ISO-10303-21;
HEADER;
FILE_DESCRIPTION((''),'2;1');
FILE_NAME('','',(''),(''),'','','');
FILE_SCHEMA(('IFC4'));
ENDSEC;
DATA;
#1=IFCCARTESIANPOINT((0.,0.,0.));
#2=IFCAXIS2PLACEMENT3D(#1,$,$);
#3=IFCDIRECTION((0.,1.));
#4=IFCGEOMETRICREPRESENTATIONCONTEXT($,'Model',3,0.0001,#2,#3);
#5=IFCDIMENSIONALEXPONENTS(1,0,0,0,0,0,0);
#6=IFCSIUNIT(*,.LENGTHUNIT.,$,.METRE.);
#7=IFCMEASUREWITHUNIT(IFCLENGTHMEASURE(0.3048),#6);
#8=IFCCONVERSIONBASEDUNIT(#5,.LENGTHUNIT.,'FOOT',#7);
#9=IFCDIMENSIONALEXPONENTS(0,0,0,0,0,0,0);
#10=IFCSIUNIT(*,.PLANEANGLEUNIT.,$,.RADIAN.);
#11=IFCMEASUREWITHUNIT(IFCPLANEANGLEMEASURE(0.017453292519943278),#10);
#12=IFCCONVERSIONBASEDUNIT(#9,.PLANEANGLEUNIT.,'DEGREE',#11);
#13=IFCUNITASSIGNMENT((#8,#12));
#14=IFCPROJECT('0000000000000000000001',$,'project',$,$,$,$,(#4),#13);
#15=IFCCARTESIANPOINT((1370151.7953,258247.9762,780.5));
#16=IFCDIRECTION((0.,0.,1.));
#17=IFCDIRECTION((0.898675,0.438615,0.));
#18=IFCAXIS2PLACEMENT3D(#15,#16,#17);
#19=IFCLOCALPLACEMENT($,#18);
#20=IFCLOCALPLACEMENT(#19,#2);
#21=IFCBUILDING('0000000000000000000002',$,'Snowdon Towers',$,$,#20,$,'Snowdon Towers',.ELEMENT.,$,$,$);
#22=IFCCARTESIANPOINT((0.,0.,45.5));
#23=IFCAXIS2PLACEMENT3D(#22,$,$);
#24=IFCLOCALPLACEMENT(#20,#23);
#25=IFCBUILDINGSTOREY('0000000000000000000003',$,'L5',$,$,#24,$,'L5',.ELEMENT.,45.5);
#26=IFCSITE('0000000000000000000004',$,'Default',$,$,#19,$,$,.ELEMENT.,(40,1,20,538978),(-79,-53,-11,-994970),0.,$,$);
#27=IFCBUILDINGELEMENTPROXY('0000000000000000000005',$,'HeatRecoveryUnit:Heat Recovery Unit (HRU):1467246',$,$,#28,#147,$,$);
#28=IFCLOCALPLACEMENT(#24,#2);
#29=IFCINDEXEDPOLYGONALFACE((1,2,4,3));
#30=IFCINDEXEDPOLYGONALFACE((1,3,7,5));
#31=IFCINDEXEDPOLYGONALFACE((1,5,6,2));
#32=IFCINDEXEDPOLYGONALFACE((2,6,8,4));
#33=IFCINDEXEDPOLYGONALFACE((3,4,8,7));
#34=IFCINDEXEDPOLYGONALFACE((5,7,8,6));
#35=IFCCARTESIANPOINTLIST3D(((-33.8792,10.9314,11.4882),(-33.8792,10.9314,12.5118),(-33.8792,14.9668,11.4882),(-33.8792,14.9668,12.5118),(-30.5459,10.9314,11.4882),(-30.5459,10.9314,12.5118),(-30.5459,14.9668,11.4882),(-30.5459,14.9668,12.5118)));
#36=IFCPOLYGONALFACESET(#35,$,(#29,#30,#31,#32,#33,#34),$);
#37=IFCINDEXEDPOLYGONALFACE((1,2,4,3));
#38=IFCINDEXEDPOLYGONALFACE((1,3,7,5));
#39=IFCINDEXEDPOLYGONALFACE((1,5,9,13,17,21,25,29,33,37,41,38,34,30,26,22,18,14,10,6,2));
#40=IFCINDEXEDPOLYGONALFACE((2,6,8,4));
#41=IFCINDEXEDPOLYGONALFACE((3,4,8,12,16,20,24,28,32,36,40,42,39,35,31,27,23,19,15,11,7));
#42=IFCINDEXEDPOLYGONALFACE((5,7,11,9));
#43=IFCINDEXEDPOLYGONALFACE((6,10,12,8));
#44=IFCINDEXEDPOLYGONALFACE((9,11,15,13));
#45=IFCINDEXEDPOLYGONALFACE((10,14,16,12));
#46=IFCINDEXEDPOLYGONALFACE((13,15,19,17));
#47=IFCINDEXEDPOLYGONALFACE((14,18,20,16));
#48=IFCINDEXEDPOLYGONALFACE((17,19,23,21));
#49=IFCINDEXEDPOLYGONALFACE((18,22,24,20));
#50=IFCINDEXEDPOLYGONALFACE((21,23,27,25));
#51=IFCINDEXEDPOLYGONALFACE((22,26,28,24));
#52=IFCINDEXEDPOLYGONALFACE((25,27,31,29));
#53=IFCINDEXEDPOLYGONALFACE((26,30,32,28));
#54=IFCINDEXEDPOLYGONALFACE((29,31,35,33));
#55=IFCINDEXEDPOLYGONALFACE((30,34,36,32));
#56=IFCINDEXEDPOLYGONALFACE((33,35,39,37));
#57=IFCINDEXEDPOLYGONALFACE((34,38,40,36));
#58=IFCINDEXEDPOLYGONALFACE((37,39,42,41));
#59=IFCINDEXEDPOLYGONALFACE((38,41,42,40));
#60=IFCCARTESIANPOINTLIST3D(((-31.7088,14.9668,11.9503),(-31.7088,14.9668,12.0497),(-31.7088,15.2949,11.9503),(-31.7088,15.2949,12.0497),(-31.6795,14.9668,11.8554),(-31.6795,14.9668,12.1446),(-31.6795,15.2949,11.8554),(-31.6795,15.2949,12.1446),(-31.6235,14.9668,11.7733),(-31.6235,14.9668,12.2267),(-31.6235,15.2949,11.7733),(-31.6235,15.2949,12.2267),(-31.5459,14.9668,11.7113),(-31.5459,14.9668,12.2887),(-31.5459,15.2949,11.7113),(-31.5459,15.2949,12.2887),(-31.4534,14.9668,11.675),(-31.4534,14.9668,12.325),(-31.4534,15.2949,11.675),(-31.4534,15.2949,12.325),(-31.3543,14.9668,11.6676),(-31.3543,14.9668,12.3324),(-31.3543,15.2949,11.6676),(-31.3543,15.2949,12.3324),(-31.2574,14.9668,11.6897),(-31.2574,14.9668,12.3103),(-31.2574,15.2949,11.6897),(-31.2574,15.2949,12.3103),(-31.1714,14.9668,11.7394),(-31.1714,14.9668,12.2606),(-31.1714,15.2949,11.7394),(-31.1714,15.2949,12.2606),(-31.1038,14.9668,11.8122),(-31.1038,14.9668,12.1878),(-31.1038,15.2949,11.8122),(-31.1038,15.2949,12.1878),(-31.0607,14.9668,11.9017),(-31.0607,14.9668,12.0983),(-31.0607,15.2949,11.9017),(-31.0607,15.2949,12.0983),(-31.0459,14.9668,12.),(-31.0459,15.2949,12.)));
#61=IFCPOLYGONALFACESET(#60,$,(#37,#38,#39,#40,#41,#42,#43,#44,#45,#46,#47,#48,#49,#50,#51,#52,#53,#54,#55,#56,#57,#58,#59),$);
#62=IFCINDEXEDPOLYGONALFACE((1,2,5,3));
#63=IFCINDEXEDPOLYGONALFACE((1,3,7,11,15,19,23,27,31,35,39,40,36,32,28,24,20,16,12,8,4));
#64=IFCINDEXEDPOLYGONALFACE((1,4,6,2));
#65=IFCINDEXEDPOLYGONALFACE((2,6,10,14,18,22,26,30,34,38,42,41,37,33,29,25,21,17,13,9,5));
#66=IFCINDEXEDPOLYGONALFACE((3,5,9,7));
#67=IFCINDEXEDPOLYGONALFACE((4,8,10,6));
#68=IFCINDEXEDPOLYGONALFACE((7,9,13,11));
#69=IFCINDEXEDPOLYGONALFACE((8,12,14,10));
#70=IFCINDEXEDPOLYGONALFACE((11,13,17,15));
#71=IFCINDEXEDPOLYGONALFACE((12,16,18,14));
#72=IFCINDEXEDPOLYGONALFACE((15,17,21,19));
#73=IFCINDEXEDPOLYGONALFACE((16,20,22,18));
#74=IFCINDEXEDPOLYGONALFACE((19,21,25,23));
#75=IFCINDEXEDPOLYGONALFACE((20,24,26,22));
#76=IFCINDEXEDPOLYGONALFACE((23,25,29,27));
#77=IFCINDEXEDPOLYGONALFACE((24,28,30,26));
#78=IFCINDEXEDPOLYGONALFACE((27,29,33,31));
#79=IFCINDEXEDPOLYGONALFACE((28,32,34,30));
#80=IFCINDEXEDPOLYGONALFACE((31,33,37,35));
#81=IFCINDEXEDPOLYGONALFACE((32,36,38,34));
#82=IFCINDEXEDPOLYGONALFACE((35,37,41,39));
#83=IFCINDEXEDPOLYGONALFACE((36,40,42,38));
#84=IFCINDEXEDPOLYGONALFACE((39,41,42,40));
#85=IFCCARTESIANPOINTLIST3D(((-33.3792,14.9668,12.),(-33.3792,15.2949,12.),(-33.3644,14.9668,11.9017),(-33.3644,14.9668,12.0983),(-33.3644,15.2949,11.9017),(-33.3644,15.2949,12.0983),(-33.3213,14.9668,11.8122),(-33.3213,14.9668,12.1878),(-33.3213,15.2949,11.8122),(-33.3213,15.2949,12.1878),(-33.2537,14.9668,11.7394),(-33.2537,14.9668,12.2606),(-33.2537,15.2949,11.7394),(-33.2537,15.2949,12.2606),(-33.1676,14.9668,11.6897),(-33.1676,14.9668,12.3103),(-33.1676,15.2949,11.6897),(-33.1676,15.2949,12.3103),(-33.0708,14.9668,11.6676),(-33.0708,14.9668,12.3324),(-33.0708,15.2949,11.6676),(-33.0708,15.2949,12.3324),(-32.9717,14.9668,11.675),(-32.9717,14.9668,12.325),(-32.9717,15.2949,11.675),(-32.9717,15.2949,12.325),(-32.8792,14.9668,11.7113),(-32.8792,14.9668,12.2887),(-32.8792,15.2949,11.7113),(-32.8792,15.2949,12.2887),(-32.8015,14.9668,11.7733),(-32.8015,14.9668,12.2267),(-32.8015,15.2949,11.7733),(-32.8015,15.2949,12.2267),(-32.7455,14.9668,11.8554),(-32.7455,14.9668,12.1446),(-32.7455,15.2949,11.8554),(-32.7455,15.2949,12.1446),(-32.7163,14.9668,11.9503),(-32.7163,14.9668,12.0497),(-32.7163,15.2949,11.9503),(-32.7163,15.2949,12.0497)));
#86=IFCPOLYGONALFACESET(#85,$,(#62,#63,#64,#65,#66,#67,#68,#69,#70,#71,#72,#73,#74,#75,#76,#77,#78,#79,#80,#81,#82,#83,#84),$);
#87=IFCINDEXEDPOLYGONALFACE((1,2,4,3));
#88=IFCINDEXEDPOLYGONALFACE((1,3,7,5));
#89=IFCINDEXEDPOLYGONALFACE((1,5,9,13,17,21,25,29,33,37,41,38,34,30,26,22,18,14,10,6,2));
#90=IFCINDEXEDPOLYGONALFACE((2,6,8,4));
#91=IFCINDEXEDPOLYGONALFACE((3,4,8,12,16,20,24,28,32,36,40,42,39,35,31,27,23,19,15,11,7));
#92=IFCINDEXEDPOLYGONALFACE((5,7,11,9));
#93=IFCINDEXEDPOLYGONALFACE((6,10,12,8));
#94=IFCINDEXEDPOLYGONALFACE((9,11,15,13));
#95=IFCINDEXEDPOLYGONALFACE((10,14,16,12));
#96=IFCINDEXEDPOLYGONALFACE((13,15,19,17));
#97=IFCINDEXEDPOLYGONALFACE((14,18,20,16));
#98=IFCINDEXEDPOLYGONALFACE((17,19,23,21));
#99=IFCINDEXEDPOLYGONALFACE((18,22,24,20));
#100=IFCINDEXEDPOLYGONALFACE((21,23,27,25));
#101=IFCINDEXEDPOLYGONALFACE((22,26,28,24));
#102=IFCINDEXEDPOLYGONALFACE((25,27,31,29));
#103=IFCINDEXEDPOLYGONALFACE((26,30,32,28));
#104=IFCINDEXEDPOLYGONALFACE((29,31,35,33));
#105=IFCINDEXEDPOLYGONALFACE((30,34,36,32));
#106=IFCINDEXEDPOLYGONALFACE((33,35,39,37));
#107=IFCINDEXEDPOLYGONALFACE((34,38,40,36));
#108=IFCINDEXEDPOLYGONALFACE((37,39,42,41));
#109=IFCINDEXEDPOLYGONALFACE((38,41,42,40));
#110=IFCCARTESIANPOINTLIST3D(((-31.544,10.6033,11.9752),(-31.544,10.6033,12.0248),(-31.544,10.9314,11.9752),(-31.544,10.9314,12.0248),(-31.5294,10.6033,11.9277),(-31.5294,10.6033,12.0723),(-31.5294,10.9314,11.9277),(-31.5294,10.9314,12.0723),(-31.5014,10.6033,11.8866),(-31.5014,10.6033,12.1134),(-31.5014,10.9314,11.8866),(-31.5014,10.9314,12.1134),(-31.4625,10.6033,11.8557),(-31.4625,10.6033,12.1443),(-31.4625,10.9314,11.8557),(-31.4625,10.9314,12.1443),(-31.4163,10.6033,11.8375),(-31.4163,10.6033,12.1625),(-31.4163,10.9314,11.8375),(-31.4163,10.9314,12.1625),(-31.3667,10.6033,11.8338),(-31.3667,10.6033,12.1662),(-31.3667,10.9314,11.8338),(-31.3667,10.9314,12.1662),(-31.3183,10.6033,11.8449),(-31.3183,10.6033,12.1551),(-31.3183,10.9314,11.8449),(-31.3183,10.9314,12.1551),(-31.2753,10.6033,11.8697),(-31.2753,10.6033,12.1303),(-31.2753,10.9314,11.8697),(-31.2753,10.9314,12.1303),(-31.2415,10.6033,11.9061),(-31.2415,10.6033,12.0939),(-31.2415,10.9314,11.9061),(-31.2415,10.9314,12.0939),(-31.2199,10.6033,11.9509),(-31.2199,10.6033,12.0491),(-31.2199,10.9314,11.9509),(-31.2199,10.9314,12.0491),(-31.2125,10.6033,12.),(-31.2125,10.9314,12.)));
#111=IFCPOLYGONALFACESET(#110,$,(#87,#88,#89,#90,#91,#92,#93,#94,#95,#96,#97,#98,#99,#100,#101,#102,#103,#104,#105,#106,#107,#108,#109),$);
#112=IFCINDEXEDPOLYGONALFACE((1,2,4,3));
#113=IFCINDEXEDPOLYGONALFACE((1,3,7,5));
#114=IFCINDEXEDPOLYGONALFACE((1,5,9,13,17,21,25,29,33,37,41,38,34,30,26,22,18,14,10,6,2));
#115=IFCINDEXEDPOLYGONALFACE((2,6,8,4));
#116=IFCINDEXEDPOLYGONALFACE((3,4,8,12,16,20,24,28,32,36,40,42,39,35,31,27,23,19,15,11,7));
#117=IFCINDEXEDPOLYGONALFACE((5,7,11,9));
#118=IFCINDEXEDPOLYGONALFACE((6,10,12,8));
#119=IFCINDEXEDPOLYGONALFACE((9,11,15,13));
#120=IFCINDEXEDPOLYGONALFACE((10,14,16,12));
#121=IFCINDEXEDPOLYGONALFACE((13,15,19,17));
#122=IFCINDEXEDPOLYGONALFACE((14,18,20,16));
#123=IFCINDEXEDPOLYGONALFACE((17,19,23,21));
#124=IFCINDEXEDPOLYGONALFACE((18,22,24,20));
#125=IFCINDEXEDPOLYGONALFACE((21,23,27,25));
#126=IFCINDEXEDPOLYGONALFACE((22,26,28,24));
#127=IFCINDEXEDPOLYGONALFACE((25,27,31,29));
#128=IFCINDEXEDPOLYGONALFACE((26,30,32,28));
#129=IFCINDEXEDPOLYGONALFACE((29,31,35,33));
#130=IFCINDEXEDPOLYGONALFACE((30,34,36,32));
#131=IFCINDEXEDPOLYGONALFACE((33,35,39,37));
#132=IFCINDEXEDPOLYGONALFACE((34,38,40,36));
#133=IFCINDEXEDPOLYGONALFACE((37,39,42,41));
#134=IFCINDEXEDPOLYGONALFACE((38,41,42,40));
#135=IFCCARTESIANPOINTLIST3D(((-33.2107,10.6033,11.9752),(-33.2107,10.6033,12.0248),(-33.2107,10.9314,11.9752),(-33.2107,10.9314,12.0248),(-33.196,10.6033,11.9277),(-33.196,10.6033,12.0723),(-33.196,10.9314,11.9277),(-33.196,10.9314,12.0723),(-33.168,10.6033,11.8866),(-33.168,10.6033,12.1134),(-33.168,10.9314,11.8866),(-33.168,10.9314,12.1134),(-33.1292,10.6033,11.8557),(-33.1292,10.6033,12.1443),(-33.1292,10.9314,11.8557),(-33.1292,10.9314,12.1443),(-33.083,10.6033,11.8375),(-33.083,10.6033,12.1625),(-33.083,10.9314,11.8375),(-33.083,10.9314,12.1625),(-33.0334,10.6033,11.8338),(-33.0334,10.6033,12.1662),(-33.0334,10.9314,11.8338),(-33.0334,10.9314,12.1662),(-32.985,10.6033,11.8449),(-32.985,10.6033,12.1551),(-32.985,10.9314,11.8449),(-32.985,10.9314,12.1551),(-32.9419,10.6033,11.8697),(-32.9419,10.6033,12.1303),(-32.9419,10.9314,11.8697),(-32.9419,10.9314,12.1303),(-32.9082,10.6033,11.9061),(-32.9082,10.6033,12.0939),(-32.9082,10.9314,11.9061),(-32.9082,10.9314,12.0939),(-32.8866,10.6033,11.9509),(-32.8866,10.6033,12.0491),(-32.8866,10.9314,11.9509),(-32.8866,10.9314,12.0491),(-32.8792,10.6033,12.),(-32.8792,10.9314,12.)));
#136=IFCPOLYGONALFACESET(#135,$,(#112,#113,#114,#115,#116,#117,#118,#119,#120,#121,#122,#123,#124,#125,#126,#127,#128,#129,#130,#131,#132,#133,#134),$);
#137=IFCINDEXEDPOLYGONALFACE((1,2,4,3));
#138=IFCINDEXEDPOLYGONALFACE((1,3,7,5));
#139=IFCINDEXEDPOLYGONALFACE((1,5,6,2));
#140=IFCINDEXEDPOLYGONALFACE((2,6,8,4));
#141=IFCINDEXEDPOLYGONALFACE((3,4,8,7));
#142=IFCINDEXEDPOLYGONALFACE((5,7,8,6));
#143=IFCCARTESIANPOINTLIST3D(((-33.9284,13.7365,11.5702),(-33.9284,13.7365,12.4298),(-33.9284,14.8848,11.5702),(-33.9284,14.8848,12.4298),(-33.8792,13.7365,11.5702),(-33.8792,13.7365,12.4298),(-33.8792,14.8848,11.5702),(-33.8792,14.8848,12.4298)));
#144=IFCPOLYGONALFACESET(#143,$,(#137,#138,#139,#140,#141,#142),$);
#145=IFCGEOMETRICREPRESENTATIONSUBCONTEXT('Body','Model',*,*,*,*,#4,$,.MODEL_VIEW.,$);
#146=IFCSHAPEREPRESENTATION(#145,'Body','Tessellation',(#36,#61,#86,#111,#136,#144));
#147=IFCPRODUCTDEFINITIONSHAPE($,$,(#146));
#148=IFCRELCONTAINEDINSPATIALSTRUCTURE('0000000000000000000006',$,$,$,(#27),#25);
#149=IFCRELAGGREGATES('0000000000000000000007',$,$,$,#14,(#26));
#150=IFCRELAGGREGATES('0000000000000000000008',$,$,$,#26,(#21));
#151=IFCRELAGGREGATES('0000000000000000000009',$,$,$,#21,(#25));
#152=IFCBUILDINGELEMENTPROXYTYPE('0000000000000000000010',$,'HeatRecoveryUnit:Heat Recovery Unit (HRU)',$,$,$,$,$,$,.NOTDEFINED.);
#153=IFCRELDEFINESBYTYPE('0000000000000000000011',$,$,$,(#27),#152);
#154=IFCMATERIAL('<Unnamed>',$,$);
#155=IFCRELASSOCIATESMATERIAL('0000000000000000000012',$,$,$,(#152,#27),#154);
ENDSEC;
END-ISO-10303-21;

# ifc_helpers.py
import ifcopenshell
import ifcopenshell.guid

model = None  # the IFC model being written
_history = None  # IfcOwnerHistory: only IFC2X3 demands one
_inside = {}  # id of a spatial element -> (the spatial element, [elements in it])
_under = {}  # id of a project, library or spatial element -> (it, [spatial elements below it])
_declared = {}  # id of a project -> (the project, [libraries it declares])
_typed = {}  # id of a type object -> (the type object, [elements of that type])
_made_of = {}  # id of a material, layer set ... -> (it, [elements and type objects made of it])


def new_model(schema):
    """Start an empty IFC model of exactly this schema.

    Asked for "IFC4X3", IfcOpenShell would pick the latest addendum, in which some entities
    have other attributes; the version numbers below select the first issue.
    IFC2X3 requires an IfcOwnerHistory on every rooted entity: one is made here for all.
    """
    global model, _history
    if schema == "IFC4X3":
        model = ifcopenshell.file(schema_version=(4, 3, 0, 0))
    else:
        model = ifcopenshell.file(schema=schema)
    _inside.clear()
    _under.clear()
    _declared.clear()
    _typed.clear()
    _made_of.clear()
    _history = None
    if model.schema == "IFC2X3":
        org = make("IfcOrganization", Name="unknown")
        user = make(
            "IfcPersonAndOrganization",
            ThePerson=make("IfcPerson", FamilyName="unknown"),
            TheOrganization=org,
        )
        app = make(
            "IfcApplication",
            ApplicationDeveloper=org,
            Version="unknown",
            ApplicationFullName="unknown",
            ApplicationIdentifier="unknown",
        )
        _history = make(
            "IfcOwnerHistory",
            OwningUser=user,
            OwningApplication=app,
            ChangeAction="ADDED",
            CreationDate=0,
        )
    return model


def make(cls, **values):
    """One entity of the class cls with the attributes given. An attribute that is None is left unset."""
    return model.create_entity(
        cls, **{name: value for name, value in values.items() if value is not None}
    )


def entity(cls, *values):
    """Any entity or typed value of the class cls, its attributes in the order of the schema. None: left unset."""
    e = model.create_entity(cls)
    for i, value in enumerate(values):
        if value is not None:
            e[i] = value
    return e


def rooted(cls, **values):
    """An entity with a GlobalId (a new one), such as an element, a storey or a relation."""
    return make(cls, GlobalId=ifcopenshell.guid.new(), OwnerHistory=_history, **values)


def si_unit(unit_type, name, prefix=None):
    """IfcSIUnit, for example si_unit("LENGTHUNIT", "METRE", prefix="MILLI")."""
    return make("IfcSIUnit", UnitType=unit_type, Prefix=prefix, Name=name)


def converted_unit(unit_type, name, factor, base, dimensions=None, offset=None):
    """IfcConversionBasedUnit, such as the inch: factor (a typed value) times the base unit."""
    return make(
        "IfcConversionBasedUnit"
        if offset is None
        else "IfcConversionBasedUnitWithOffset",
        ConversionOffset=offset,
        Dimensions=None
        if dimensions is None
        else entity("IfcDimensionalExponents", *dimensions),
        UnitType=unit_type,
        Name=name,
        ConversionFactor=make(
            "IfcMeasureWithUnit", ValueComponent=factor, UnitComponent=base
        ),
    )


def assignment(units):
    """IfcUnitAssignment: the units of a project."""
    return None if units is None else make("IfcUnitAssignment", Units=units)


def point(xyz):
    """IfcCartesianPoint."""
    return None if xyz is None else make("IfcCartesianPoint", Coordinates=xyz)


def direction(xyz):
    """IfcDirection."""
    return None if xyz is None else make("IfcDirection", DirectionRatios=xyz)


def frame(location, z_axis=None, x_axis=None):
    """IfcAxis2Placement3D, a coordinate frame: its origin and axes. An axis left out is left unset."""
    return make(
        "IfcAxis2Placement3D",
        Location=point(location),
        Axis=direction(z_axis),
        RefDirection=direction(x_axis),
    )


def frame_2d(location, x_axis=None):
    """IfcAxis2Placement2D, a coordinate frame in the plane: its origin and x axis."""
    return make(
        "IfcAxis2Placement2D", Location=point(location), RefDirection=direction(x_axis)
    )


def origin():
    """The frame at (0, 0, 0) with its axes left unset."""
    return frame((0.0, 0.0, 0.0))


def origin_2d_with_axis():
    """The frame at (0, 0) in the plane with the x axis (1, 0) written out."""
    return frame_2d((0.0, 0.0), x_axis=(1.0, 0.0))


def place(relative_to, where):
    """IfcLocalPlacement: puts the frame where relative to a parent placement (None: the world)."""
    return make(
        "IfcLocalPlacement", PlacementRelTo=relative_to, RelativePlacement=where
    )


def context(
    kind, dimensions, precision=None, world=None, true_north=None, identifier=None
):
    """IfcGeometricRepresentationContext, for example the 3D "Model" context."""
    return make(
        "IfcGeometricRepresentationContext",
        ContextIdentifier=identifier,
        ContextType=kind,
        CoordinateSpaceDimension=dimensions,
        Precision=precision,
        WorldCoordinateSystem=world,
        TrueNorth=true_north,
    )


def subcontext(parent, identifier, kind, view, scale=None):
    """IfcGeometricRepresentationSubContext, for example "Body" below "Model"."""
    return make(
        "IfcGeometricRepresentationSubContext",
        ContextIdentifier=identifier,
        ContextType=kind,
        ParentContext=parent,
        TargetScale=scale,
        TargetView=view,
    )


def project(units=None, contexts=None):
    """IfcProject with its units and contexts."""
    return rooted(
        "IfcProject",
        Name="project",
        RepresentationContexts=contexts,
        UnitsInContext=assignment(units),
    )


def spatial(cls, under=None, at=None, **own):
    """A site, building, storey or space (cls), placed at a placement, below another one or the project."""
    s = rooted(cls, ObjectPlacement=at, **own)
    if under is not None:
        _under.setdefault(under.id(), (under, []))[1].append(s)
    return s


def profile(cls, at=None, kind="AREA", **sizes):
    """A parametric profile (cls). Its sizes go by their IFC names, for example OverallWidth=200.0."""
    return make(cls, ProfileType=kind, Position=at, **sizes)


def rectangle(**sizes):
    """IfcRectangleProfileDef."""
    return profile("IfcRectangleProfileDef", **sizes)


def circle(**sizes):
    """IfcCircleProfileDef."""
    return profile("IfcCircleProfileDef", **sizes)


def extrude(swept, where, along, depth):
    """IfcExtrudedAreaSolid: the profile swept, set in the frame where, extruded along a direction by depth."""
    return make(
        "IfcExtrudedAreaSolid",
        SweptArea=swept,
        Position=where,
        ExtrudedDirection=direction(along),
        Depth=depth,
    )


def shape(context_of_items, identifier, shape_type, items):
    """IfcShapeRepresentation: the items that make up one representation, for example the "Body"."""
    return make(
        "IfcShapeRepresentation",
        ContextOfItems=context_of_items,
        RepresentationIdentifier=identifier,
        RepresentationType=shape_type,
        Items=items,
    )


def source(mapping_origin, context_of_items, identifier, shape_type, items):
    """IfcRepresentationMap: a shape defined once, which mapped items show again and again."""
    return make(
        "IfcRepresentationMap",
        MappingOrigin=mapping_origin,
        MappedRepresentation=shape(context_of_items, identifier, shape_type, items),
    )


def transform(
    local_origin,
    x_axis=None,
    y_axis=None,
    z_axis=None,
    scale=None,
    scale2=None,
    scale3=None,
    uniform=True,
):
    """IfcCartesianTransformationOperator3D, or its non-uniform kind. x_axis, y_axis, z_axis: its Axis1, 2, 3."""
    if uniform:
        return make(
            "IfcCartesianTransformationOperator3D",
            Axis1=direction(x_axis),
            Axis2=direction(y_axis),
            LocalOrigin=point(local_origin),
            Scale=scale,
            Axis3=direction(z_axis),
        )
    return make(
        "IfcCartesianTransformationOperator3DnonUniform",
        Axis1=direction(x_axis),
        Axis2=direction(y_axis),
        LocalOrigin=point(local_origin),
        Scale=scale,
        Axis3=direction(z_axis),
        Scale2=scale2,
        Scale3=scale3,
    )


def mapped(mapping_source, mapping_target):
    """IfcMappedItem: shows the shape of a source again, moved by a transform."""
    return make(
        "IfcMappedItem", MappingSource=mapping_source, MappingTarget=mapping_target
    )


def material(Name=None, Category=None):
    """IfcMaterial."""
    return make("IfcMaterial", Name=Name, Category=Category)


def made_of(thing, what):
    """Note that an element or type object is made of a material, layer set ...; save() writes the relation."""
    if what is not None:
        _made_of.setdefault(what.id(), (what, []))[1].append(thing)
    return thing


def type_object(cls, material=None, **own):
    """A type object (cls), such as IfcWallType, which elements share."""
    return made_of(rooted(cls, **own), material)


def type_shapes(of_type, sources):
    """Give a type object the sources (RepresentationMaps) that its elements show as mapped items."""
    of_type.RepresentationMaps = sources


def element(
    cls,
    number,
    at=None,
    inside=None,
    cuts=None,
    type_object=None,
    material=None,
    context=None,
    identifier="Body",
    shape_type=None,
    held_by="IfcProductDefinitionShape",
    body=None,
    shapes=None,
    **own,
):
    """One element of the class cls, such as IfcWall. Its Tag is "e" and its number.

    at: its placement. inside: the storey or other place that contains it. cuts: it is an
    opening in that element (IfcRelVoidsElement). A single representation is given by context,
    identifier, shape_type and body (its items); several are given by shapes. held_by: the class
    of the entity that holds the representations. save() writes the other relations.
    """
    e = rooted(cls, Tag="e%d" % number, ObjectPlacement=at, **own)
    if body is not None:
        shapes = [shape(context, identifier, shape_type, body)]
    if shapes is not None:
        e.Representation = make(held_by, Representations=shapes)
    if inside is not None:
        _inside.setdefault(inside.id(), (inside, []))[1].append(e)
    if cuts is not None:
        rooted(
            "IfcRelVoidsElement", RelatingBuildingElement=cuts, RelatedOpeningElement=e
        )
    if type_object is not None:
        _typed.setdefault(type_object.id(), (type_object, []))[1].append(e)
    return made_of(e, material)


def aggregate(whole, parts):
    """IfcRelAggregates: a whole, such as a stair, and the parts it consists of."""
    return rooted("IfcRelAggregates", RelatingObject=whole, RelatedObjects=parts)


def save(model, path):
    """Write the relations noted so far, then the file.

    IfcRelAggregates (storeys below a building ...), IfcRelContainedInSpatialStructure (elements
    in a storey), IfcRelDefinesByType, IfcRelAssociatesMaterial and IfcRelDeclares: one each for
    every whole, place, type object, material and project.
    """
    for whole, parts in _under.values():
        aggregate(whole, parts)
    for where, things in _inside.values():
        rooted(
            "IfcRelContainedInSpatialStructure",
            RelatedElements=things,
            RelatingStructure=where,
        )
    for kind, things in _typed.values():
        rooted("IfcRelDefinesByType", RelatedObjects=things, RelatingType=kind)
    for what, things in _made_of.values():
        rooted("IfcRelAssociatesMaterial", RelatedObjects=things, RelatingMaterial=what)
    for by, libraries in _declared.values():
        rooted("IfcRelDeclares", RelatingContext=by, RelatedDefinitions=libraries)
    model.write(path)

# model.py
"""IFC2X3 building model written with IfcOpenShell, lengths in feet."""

from ifc_helpers import new_model, entity, si_unit, converted_unit, direction, frame, frame_2d, origin, origin_2d_with_axis, place, context, subcontext, project, spatial, rectangle, circle, extrude, source, transform, mapped, material, type_object, type_shapes, element, save


model = new_model("IFC2X3")

# Units and contexts
model_context = context("Model", 3, precision=0.0001, world=origin(), true_north=direction((0.0, 1.0)))
body_context = subcontext(model_context, "Body", "Model", "MODEL_VIEW")
ifc_project = project(units=[converted_unit("LENGTHUNIT", "FOOT", entity("IfcLengthMeasure", 0.3048), si_unit("LENGTHUNIT", "METRE"), dimensions=[1, 0, 0, 0, 0, 0, 0]), converted_unit("PLANEANGLEUNIT", "DEGREE", entity("IfcPlaneAngleMeasure", 0.017453292519943278), si_unit("PLANEANGLEUNIT", "RADIAN"), dimensions=[0, 0, 0, 0, 0, 0, 0])], contexts=[model_context])

# Site, building, storey
site_placement = place(None, frame((1370151.7953, 258247.9762, 780.5), z_axis=(0.0, 0.0, 1.0), x_axis=(0.898675, 0.438615, 0.0)))
site = spatial("IfcSite", under=ifc_project, at=site_placement, Name="Default", CompositionType="ELEMENT", RefLatitude=(40, 1, 20, 538978), RefLongitude=(-79, -53, -11, -994970), RefElevation=0.0)
building_placement = place(site_placement, origin())
building = spatial("IfcBuilding", under=site, at=building_placement, Name="Snowdon Towers", LongName="Snowdon Towers", CompositionType="ELEMENT")
storey_placement = place(building_placement, frame((0.0, 0.0, 45.5)))
storey = spatial("IfcBuildingStorey", under=building, at=storey_placement, Name="L5", LongName="L5", CompositionType="ELEMENT", Elevation=45.5)

# Shared definitions
ifc_material = material(Name="<Unnamed>")

# Building element proxy
building_element_proxy_type = type_object("IfcBuildingElementProxyType", Name="HeatRecoveryUnit:Heat Recovery Unit (HRU)", PredefinedType="NOTDEFINED", material=ifc_material)
shared_shape_1 = source(origin(), body_context, "Body", "SweptSolid", [
    extrude(rectangle(XDim=3.3333, YDim=4.0354, at=origin_2d_with_axis()), frame((0.0, 0.0, 0.0), z_axis=(0.0, 0.0, 1.0), x_axis=(-1.0, 0.0, 0.0)), (0.0, 0.0, 1.0), 1.0236),
    extrude(circle(Radius=0.3333, at=frame_2d((0.0, 0.0), x_axis=(1.0, 0.0))), frame((-0.8333, -2.3458, 0.5118), z_axis=(0.0, 1.0, 0.0), x_axis=(-1.0, 0.0, 0.0)), (0.0, 0.0, 1.0), 0.3281),
    extrude(circle(Radius=0.3333, at=frame_2d((0.0, 0.0), x_axis=(1.0, 0.0))), frame((0.8333, -2.3458, 0.5118), z_axis=(0.0, 1.0, 0.0), x_axis=(1.0, 0.0, 0.0)), (0.0, 0.0, 1.0), 0.3281),
    extrude(circle(Radius=0.1667, at=frame_2d((0.0, 0.0), x_axis=(1.0, 0.0))), frame((-0.8333, 2.0177, 0.5118), z_axis=(0.0, 1.0, 0.0), x_axis=(-1.0, 0.0, 0.0)), (0.0, 0.0, 1.0), 0.3281),
    extrude(circle(Radius=0.1667, at=frame_2d((0.0, 0.0), x_axis=(1.0, 0.0))), frame((0.8333, 2.0177, 0.5118), z_axis=(0.0, 1.0, 0.0), x_axis=(-1.0, 0.0, 0.0)), (0.0, 0.0, 1.0), 0.3281),
    extrude(rectangle(XDim=0.0492, YDim=1.1483, at=origin_2d_with_axis()), frame((1.6913, -1.3615, 0.082), z_axis=(0.0, 0.0, 1.0), x_axis=(-1.0, 0.0, 0.0)), (0.0, 0.0, 1.0), 0.8596),
])
type_shapes(building_element_proxy_type, [shared_shape_1])
for number, where, z_axis, x_axis, name in (
    (1, (-32.2125, 12.9491, 11.4882), (0.0, 0.0, 1.0), (-1.0, 0.0, 0.0), "HeatRecoveryUnit:Heat Recovery Unit (HRU):1467246"),
):
    element("IfcBuildingElementProxy", number, at=place(storey_placement, frame(where, z_axis=z_axis, x_axis=x_axis)), inside=storey, type_object=building_element_proxy_type, material=ifc_material, Name=name, context=body_context, shape_type="MappedRepresentation", body=[
        mapped(shared_shape_1, transform((0.0, 0.0, 0.0), scale=1.0)),
    ])

save(model, "model.ifc")
